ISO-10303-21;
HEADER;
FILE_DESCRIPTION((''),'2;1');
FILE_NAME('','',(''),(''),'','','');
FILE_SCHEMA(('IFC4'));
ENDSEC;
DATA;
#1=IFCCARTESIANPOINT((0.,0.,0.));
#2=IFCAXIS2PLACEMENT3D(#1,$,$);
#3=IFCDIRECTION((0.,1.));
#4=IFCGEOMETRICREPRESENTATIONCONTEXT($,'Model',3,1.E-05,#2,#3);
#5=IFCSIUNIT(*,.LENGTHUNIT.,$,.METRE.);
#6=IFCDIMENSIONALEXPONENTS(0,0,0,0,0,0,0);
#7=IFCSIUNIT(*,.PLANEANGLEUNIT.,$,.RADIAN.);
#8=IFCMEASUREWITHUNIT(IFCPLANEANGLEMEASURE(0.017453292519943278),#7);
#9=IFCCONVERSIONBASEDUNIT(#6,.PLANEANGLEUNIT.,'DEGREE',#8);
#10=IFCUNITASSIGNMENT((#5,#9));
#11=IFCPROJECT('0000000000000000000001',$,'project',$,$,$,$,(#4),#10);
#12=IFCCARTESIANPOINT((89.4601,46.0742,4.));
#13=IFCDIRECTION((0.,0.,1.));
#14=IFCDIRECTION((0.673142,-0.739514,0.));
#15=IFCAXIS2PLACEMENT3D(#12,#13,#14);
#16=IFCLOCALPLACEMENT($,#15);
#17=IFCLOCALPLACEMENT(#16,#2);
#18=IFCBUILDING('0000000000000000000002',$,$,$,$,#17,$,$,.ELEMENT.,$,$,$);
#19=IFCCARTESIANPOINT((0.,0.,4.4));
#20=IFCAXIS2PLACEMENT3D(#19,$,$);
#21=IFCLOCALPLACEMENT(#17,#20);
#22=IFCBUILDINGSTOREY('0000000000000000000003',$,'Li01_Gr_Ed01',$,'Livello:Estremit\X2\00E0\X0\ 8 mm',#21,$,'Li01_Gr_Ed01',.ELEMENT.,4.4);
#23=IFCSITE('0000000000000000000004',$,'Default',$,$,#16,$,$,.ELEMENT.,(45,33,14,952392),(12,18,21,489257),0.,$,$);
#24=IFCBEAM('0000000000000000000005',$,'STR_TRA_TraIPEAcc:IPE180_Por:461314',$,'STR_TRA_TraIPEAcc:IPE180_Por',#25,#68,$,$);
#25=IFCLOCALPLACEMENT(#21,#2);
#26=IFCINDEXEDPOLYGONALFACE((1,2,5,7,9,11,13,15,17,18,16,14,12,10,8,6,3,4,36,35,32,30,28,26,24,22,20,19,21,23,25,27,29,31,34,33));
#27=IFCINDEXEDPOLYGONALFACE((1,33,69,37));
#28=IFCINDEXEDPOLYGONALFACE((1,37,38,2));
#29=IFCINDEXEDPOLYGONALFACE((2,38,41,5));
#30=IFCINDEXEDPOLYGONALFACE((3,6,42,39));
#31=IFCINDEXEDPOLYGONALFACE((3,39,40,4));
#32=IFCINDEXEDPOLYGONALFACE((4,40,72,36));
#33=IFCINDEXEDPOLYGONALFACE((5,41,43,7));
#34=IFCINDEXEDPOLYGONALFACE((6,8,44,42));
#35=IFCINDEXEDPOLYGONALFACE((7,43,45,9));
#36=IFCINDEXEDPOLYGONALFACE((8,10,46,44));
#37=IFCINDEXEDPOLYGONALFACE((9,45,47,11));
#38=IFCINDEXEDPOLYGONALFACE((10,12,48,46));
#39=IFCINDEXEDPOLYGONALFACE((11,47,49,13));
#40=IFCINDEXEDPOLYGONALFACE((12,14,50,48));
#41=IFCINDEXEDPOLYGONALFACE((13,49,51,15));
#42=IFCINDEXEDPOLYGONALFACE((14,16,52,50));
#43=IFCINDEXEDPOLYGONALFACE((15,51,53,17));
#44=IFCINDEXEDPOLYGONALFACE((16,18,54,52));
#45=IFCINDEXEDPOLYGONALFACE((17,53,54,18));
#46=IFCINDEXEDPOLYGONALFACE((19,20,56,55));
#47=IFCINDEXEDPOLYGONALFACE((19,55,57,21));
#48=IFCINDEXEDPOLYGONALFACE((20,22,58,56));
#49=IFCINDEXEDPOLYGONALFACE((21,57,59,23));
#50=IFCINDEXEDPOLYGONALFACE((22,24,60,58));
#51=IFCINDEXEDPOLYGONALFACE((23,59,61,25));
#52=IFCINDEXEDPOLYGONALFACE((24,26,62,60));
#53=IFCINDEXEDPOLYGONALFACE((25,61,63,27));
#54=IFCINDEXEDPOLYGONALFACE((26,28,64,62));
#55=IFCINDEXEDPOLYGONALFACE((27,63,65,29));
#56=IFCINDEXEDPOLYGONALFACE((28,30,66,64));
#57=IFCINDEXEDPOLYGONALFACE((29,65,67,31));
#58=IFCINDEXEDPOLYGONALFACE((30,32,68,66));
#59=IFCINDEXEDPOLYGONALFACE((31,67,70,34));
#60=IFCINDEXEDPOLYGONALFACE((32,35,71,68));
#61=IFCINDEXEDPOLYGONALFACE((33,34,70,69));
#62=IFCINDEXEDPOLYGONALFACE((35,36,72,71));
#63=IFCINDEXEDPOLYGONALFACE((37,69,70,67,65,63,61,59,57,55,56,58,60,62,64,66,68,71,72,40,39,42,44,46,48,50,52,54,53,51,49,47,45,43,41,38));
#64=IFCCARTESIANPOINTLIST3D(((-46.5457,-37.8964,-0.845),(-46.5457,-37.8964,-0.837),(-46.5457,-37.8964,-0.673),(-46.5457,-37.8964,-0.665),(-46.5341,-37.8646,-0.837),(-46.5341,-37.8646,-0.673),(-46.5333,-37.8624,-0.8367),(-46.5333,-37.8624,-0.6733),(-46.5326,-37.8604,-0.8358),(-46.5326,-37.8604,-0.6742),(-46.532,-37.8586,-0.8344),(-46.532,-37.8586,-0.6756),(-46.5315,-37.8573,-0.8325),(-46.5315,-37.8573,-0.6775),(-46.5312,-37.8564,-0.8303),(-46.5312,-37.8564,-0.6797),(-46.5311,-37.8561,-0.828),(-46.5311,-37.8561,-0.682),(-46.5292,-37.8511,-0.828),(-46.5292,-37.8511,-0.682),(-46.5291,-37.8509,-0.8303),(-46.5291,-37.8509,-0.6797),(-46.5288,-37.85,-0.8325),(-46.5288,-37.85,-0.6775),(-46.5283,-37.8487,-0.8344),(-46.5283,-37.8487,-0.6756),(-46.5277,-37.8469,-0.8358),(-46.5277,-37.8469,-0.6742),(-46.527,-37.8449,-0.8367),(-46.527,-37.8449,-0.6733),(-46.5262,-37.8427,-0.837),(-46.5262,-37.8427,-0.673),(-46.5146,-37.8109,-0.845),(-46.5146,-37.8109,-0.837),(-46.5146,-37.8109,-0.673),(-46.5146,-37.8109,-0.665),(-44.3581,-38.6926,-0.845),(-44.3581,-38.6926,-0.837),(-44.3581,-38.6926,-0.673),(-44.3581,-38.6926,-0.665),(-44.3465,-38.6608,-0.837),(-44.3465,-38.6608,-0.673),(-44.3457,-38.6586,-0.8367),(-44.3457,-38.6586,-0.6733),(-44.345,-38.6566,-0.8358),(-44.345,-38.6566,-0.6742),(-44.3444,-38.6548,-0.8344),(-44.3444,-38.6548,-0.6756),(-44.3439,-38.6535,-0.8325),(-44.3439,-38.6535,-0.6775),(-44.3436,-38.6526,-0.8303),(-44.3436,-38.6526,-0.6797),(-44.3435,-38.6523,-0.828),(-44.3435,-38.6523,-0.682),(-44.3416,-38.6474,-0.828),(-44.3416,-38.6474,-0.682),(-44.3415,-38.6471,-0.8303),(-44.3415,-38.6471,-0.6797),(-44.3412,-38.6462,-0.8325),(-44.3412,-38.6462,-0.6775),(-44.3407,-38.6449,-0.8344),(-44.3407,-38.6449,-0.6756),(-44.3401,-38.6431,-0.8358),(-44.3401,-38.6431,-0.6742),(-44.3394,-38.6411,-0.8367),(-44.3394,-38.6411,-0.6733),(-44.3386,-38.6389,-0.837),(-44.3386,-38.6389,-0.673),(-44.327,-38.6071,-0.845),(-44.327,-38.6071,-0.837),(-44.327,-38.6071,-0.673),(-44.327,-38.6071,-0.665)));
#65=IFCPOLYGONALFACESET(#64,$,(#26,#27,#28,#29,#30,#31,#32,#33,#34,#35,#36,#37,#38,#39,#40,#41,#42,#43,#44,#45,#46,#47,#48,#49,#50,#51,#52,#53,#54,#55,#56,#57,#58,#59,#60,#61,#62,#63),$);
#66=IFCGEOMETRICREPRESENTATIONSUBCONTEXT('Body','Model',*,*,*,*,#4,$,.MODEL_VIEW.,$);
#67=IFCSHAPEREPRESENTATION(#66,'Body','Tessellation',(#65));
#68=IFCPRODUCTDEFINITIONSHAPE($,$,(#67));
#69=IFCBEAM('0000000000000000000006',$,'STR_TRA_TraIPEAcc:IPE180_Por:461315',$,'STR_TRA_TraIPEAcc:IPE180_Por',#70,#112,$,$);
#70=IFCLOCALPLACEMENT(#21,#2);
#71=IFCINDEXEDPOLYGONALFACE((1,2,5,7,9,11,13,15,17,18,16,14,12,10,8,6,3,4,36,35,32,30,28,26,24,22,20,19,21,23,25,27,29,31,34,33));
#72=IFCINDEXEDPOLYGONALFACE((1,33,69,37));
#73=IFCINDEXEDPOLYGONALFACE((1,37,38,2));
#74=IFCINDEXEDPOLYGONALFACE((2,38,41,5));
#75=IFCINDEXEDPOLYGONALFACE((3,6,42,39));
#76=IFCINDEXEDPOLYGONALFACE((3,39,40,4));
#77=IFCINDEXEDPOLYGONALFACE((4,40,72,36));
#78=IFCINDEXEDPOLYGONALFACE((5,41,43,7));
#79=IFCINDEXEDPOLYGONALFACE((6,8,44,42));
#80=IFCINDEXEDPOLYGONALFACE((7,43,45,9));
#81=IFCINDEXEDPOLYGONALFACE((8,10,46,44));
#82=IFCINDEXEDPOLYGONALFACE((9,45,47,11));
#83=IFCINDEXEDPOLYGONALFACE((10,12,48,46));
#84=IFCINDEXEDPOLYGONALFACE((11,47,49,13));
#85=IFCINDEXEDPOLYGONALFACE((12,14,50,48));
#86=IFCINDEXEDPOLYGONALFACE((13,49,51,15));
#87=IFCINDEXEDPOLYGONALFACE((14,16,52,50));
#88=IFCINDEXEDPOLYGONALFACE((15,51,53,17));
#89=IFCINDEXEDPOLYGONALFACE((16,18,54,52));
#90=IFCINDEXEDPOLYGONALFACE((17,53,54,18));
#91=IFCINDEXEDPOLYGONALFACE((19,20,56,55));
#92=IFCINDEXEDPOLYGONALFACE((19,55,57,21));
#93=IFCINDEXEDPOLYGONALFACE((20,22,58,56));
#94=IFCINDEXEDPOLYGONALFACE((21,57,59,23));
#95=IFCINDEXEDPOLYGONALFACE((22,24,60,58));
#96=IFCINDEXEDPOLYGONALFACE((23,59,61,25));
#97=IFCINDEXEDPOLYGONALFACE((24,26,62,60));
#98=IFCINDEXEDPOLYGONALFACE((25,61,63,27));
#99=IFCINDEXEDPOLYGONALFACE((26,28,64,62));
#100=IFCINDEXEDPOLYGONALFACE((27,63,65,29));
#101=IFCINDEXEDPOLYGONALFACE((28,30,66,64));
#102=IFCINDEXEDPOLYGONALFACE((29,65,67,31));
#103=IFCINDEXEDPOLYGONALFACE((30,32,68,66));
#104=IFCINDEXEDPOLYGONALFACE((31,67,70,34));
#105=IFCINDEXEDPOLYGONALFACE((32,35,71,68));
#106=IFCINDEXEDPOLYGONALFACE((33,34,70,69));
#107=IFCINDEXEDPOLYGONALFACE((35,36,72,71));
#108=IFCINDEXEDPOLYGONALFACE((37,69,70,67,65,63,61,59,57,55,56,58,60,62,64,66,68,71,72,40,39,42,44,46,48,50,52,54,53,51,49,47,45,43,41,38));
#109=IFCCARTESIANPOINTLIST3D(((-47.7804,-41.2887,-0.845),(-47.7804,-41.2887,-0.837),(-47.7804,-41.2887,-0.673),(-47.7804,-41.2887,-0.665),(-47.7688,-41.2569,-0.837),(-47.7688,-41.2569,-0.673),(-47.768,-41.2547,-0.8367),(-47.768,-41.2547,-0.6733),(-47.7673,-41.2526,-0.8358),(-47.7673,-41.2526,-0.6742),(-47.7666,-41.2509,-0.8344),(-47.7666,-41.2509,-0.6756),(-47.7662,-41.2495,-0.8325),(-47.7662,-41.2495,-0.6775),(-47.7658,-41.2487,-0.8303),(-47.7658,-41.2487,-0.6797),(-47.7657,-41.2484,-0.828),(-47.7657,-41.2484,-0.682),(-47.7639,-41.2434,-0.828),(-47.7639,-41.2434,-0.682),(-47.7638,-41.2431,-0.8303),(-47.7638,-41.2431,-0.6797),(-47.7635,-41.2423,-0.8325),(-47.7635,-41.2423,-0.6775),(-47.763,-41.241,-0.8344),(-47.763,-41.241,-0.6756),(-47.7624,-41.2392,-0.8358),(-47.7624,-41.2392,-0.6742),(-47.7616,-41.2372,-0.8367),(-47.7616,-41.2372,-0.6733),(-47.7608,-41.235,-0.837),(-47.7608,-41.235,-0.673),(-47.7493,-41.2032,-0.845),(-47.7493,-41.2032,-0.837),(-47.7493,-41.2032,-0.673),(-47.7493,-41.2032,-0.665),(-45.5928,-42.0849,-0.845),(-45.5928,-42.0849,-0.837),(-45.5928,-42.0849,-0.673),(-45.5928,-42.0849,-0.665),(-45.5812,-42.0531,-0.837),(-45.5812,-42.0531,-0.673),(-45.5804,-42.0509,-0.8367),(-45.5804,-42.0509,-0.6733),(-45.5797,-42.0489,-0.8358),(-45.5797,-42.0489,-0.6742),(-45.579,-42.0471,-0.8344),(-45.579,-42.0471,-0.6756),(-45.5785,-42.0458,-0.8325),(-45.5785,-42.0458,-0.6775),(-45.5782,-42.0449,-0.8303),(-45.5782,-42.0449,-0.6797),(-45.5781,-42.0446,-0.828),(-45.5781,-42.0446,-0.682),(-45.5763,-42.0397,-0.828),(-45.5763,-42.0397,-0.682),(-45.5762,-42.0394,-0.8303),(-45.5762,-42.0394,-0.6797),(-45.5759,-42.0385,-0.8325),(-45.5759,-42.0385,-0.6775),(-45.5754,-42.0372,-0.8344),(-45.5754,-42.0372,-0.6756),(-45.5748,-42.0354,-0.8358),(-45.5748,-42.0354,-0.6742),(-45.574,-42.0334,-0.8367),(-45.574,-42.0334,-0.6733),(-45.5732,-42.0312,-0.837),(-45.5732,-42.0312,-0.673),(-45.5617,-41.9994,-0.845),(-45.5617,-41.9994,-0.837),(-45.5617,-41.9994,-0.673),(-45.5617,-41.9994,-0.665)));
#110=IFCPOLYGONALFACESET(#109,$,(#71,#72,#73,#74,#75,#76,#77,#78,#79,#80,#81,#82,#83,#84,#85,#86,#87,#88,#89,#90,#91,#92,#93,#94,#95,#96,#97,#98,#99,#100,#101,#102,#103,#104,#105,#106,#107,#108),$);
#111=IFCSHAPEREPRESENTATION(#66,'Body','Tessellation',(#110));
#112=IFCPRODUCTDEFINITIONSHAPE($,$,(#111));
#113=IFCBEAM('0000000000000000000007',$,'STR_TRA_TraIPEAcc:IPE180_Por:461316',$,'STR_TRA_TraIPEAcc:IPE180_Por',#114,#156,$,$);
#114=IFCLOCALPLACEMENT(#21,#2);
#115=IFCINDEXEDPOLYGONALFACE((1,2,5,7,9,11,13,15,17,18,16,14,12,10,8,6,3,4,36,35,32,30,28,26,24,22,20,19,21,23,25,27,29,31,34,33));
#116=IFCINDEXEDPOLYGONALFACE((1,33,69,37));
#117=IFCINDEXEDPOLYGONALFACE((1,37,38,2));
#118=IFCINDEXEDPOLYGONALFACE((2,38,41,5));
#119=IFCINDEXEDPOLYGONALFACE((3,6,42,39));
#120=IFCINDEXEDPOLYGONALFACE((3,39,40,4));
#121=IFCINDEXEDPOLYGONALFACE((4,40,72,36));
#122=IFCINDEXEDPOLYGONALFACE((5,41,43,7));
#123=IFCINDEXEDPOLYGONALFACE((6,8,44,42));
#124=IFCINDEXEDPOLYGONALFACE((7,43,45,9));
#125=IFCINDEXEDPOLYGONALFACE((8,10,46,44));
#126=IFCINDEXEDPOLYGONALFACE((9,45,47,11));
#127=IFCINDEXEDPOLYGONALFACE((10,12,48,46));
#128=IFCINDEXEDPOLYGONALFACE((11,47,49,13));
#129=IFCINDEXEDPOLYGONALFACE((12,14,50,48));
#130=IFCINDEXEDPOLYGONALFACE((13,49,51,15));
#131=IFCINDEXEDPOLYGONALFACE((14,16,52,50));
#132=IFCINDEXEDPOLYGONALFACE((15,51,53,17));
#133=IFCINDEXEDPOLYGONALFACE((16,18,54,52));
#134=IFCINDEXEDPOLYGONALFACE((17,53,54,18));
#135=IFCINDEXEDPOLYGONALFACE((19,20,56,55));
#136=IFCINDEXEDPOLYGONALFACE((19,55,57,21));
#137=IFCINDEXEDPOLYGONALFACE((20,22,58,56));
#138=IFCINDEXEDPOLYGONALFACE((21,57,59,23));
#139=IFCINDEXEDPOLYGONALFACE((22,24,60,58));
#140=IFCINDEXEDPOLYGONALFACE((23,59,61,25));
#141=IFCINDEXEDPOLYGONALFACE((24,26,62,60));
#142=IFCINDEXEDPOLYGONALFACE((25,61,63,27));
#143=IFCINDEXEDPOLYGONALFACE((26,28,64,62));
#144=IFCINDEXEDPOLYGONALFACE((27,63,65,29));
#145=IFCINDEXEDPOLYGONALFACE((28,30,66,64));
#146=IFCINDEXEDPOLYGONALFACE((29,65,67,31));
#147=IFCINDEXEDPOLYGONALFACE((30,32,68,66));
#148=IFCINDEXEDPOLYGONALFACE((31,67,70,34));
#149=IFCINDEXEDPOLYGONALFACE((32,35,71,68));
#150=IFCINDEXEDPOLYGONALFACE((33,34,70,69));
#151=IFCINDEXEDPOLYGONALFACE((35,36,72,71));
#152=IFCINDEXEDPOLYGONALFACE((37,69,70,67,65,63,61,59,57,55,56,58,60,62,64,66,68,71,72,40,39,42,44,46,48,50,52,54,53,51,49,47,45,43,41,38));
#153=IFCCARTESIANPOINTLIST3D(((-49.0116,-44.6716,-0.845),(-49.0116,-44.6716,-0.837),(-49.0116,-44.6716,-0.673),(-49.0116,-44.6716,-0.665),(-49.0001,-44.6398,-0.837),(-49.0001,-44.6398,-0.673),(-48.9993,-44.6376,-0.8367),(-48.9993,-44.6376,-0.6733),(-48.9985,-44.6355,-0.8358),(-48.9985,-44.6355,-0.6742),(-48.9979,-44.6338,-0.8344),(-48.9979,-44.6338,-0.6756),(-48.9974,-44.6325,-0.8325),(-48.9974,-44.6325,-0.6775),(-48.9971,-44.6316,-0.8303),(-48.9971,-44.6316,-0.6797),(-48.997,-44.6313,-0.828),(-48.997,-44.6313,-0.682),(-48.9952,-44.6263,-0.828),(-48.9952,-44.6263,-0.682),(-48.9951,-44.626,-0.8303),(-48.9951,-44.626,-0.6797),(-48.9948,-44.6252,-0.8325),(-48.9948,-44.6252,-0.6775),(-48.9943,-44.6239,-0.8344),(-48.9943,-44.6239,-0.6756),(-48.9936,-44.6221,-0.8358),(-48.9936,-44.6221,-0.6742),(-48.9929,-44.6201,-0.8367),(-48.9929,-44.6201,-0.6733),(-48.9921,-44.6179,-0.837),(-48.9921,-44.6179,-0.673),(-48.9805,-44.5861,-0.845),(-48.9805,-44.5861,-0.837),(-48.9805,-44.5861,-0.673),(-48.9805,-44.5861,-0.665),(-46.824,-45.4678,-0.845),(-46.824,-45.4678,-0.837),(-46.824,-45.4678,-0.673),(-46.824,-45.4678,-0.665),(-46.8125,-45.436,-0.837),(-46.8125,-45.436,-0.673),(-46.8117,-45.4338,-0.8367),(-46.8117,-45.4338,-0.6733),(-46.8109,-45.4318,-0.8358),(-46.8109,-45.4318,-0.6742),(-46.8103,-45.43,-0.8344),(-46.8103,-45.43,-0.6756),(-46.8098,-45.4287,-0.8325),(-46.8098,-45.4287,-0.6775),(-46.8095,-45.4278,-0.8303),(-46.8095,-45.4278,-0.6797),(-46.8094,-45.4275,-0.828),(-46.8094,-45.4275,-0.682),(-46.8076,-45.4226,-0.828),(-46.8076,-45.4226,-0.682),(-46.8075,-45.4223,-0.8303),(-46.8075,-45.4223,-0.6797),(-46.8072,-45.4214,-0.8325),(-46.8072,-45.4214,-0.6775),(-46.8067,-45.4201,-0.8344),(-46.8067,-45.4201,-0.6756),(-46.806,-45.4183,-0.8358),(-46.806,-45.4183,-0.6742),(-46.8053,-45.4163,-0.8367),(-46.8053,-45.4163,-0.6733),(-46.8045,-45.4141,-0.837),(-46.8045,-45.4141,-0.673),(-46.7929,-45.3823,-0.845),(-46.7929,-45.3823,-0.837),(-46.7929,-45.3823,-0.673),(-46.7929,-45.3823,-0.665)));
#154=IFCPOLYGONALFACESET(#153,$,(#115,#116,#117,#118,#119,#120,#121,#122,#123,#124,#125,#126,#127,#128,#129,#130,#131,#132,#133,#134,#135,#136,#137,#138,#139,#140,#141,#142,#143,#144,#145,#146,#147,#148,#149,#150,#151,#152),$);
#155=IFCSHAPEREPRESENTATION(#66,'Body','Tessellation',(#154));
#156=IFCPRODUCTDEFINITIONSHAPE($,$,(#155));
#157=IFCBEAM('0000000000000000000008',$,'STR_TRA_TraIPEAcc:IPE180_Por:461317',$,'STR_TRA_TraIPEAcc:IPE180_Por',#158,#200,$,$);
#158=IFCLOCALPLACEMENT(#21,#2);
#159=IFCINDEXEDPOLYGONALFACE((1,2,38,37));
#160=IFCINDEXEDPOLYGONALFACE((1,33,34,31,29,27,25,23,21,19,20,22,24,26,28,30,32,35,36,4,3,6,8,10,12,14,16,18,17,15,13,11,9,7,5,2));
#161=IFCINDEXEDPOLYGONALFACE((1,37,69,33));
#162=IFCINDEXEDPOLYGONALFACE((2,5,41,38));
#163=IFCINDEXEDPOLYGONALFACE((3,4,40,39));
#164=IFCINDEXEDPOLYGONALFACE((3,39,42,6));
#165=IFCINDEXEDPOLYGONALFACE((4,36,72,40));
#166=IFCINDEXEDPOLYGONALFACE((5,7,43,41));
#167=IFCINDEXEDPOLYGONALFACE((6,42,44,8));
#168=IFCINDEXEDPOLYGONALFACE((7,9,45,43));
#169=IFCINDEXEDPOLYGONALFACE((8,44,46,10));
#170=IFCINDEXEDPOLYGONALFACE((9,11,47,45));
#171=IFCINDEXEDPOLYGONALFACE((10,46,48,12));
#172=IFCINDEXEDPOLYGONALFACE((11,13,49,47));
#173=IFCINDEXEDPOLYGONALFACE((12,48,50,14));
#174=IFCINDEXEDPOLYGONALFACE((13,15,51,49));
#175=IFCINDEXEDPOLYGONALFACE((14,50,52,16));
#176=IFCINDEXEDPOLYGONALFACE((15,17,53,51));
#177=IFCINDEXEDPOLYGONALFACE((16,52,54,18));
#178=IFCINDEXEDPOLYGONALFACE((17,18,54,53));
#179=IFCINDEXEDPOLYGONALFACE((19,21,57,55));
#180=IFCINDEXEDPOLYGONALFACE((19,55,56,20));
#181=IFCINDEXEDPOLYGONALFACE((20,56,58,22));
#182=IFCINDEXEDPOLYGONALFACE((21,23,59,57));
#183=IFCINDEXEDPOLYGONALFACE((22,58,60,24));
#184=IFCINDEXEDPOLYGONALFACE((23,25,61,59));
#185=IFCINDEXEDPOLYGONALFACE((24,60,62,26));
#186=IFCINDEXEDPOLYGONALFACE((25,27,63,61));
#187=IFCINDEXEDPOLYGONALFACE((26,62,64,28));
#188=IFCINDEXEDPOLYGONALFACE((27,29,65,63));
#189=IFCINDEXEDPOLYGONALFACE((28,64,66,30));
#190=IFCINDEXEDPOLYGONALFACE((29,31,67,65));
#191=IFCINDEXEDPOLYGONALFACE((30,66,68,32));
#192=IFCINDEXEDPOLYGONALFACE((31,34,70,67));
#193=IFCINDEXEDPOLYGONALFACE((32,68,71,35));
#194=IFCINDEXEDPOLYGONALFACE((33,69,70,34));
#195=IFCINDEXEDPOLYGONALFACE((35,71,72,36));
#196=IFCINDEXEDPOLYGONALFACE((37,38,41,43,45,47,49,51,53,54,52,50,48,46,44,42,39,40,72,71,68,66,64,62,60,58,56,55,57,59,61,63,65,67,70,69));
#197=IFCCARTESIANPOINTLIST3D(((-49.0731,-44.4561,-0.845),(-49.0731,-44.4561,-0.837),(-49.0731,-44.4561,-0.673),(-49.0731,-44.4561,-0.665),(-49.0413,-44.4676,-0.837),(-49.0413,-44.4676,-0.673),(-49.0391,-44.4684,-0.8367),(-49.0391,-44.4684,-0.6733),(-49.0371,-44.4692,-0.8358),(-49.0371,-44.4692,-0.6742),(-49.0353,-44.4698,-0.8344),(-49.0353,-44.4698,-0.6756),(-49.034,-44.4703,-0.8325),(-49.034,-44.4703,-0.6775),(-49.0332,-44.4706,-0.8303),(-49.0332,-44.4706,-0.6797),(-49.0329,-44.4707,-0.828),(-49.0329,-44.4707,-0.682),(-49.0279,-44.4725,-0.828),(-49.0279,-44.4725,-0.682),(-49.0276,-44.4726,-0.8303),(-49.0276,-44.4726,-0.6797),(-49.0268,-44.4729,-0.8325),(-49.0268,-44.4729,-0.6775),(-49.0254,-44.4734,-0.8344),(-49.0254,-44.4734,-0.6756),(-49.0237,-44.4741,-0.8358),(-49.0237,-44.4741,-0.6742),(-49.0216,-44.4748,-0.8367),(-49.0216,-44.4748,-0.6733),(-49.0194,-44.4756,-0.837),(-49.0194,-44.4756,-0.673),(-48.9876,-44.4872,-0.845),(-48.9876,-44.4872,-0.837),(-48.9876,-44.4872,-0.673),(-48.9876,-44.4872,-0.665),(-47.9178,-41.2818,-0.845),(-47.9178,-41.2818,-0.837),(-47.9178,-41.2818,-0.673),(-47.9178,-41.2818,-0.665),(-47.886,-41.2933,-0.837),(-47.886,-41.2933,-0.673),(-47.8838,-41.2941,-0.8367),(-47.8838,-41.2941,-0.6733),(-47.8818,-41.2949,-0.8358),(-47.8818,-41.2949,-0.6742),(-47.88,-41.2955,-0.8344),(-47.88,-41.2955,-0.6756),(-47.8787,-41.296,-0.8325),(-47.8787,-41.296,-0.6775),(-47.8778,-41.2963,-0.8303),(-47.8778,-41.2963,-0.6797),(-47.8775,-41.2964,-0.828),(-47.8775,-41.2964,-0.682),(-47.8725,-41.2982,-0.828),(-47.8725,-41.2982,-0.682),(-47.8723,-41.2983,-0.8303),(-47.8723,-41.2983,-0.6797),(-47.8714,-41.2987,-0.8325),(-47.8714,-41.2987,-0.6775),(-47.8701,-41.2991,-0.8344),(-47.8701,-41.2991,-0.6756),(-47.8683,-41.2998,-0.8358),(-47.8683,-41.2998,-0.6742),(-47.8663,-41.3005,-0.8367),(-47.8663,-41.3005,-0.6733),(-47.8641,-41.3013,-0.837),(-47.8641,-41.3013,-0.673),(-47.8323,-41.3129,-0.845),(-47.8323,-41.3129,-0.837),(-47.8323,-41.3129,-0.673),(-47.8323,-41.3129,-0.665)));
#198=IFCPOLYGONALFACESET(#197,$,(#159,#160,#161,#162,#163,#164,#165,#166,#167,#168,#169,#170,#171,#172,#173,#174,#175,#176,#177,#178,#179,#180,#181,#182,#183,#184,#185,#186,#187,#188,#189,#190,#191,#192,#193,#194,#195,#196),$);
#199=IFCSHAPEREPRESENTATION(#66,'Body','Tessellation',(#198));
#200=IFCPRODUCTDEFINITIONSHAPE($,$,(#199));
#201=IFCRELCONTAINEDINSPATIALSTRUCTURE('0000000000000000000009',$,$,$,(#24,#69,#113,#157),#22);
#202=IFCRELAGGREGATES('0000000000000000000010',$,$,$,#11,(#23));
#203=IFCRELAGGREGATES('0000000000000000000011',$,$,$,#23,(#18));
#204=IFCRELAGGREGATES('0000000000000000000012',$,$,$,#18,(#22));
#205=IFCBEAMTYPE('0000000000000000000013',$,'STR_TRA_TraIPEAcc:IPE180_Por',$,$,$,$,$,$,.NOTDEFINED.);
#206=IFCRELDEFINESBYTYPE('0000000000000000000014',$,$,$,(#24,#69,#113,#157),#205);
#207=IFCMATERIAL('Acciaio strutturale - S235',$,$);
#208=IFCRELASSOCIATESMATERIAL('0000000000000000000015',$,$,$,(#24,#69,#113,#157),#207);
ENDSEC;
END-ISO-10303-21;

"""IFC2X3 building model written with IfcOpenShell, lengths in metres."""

from ifc_helpers import new_model, entity, si_unit, converted_unit, direction, frame, frame_2d, origin, place, context, subcontext, project, spatial, i_section, extrude, material, type_object, element, save


model = new_model("IFC2X3")

# Units and contexts
model_context = context("Model", 3, precision=1e-05, world=origin(), true_north=direction((0.0, 1.0)))
body_context = subcontext(model_context, "Body", "Model", "MODEL_VIEW")
ifc_project = project(units=[si_unit("LENGTHUNIT", "METRE"), converted_unit("PLANEANGLEUNIT", "DEGREE", entity("IfcPlaneAngleMeasure", 0.017453292519943278), si_unit("PLANEANGLEUNIT", "RADIAN"), dimensions=[0, 0, 0, 0, 0, 0, 0])], contexts=[model_context])

# Site, building, storey
site_placement = place(None, frame((89.4601, 46.0742, 4.0), z_axis=(0.0, 0.0, 1.0), x_axis=(0.673142, -0.739514, 0.0)))
site = spatial("IfcSite", under=ifc_project, at=site_placement, Name="Default", CompositionType="ELEMENT", RefLatitude=(45, 33, 14, 952392), RefLongitude=(12, 18, 21, 489257), RefElevation=0.0)
building_placement = place(site_placement, origin())
building = spatial("IfcBuilding", under=site, at=building_placement, CompositionType="ELEMENT")
storey_placement = place(building_placement, frame((0.0, 0.0, 4.4)))
storey = spatial("IfcBuildingStorey", under=building, at=storey_placement, Name="Li01_Gr_Ed01", ObjectType="Livello:Estremità 8 mm", LongName="Li01_Gr_Ed01", CompositionType="ELEMENT", Elevation=4.4)

# Beams
ifc_material_1 = material(Name="Acciaio strutturale - S235")
beam_type = type_object("IfcBeamType", Name="STR_TRA_TraIPEAcc:IPE180_Por", PredefinedType="NOTDEFINED")
beam_1_placement = place(storey_placement, frame((-46.611, -37.8242, -0.665), z_axis=(0.0, 0.0, 1.0), x_axis=(0.939693, -0.34202, 0.0)))
element("IfcBeam", 1, at=beam_1_placement, inside=storey, type_object=beam_type, material=ifc_material_1, Name="STR_TRA_TraIPEAcc:IPE180_Por:461314", ObjectType="STR_TRA_TraIPEAcc:IPE180_Por", context=body_context, shape_type="SweptSolid", body=[
    extrude(i_section(OverallWidth=0.091, OverallDepth=0.18, WebThickness=0.0053, FlangeThickness=0.008, FilletRadius=0.009, at=frame_2d((0.0, 0.0), x_axis=(0.0, 1.0))), frame((0.086, 0.0, -0.09), z_axis=(1.0, 0.0, 0.0), x_axis=(0.0, 0.0, -1.0)), (0.0, 0.0, 1.0), 2.328),
])
beam_2_placement = place(storey_placement, frame((-47.8456, -41.2165, -0.665), z_axis=(0.0, 0.0, 1.0), x_axis=(0.939693, -0.34202, 0.0)))
element("IfcBeam", 2, at=beam_2_placement, inside=storey, type_object=beam_type, material=ifc_material_1, Name="STR_TRA_TraIPEAcc:IPE180_Por:461315", ObjectType="STR_TRA_TraIPEAcc:IPE180_Por", context=body_context, shape_type="SweptSolid", body=[
    extrude(i_section(OverallWidth=0.091, OverallDepth=0.18, WebThickness=0.0053, FlangeThickness=0.008, FilletRadius=0.009, at=frame_2d((0.0, 0.0), x_axis=(0.0, 1.0))), frame((0.086, 0.0, -0.09), z_axis=(1.0, 0.0, 0.0), x_axis=(0.0, 0.0, -1.0)), (0.0, 0.0, 1.0), 2.328),
])
beam_3_placement = place(storey_placement, frame((-49.0769, -44.5994, -0.665), z_axis=(0.0, 0.0, 1.0), x_axis=(0.939693, -0.34202, 0.0)))
element("IfcBeam", 3, at=beam_3_placement, inside=storey, type_object=beam_type, material=ifc_material_1, Name="STR_TRA_TraIPEAcc:IPE180_Por:461316", ObjectType="STR_TRA_TraIPEAcc:IPE180_Por", context=body_context, shape_type="SweptSolid", body=[
    extrude(i_section(OverallWidth=0.091, OverallDepth=0.18, WebThickness=0.0053, FlangeThickness=0.008, FilletRadius=0.009, at=frame_2d((0.0, 0.0), x_axis=(0.0, 1.0))), frame((0.086, 0.0, -0.09), z_axis=(1.0, 0.0, 0.0), x_axis=(0.0, 0.0, -1.0)), (0.0, 0.0, 1.0), 2.328),
])
beam_4_placement = place(storey_placement, frame((-49.0769, -44.5994, -0.665), z_axis=(0.0, 0.0, 1.0), x_axis=(0.34202, 0.939693, 0.0)))
element("IfcBeam", 4, at=beam_4_placement, inside=storey, type_object=beam_type, material=ifc_material_1, Name="STR_TRA_TraIPEAcc:IPE180_Por:461317", ObjectType="STR_TRA_TraIPEAcc:IPE180_Por", context=body_context, shape_type="SweptSolid", body=[
    extrude(i_section(OverallWidth=0.091, OverallDepth=0.18, WebThickness=0.0053, FlangeThickness=0.008, FilletRadius=0.009, at=frame_2d((0.0, 0.0), x_axis=(0.0, 1.0))), frame((0.136, 0.0, -0.09), z_axis=(1.0, 0.0, 0.0), x_axis=(0.0, 0.0, -1.0)), (0.0, 0.0, 1.0), 3.378),
])

save(model, "model.ifc")
